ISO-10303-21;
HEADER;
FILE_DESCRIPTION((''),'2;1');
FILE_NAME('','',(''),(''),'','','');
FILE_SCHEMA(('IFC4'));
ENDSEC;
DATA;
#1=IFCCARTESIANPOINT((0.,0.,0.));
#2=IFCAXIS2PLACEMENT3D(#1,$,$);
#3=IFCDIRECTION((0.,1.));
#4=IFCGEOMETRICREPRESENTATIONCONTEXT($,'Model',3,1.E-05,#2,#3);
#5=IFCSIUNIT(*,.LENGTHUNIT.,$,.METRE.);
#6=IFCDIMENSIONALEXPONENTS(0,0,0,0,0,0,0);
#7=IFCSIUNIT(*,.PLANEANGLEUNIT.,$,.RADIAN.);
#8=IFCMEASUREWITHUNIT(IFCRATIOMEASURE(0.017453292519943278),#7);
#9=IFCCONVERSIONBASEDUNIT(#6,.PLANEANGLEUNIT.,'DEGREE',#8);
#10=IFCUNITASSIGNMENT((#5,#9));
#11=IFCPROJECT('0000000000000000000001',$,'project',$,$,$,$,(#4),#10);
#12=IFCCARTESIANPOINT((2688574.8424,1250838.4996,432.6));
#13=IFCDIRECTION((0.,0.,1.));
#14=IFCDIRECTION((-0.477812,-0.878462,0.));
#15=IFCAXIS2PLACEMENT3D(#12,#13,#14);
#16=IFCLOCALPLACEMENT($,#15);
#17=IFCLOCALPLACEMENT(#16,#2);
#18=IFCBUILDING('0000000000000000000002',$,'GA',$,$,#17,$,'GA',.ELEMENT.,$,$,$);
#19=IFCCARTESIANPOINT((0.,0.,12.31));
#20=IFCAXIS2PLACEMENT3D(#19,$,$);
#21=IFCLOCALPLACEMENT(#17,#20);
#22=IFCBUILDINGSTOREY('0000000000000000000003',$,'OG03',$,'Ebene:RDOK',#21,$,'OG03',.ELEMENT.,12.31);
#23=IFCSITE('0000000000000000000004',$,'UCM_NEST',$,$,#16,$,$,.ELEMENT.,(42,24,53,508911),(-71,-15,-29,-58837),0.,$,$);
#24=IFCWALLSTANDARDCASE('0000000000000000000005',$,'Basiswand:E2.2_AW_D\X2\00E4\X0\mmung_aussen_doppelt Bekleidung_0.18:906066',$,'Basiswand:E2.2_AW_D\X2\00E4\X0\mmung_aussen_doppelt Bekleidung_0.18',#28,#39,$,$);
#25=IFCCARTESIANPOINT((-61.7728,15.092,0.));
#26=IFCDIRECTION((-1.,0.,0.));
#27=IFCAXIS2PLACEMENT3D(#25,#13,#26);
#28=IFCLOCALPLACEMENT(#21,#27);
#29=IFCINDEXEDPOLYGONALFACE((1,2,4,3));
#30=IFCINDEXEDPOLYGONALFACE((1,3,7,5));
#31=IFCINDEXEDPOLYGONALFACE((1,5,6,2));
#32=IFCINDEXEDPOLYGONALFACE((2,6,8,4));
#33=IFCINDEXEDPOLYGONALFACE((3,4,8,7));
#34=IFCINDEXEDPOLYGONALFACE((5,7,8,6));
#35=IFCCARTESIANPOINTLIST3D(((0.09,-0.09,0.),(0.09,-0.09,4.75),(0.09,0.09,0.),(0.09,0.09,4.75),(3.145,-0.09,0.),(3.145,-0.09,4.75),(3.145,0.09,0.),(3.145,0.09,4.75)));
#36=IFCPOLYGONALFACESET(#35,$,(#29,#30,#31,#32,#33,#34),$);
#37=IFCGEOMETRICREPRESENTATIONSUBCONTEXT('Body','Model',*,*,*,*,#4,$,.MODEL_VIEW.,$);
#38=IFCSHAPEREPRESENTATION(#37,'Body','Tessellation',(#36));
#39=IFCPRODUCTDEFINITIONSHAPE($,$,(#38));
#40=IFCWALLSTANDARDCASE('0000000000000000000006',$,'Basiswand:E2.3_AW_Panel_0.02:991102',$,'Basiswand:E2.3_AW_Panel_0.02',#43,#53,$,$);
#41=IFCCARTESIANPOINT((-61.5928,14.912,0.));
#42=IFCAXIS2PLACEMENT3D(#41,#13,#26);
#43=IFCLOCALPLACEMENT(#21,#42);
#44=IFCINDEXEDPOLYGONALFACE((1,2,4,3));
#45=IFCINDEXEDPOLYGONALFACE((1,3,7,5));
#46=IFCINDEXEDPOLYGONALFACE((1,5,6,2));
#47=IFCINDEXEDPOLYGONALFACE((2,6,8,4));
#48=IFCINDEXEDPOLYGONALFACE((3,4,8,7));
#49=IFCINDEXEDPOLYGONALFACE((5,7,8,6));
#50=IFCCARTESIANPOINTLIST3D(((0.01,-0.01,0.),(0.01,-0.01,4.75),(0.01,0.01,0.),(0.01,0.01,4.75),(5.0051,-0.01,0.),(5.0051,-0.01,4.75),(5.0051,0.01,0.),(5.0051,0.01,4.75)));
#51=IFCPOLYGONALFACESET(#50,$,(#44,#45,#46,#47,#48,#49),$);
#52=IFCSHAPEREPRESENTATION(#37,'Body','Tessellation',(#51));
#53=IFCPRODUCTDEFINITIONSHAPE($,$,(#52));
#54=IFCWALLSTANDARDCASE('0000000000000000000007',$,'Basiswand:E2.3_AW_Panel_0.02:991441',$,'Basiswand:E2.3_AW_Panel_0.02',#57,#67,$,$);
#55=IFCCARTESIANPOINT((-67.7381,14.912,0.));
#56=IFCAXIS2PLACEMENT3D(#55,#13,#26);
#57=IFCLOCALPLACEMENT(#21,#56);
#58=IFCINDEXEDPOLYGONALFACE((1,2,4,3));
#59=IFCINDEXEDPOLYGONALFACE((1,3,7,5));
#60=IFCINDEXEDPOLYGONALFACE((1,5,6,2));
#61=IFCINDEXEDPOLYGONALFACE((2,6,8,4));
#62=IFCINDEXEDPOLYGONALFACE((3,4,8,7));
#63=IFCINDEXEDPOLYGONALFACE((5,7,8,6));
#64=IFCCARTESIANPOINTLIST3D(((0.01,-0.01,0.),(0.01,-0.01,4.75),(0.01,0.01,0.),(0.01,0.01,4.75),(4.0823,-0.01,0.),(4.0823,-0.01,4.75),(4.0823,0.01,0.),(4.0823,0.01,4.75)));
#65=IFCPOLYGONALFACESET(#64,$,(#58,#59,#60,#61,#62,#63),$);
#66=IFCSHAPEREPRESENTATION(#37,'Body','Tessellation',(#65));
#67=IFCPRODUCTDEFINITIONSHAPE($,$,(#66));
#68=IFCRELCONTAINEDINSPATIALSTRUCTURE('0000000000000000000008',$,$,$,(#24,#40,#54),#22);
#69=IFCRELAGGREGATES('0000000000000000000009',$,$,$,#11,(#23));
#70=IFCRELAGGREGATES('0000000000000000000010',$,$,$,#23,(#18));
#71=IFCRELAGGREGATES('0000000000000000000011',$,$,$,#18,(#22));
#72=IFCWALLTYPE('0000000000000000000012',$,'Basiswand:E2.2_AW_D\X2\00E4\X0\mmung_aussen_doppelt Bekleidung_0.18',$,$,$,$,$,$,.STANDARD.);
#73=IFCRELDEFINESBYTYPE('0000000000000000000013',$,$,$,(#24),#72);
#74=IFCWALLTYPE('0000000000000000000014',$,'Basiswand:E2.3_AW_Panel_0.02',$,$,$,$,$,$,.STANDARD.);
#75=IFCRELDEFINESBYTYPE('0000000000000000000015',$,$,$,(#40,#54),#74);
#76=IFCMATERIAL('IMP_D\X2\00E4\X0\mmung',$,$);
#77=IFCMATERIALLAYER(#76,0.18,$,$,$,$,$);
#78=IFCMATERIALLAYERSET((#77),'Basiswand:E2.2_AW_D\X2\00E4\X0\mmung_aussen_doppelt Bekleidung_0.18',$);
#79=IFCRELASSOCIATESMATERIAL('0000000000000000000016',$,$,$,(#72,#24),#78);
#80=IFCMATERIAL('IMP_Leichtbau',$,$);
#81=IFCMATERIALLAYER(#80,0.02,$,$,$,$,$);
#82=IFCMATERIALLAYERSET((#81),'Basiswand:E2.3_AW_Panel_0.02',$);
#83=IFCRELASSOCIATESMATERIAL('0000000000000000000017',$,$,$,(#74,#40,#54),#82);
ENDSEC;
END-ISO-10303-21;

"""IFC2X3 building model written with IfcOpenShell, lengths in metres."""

from ifc_helpers import new_model, entity, si_unit, converted_unit, direction, frame, frame_2d, origin, place, context, subcontext, project, spatial, rectangle, extrude, material, layer, layer_set, layer_usage, type_object, element, save


model = new_model("IFC2X3")

# Units and contexts
model_context = context("Model", 3, precision=1e-05, world=origin(), true_north=direction((0.0, 1.0)))
body_context = subcontext(model_context, "Body", "Model", "MODEL_VIEW")
ifc_project = project(units=[si_unit("LENGTHUNIT", "METRE"), converted_unit("PLANEANGLEUNIT", "DEGREE", entity("IfcRatioMeasure", 0.017453292519943278), si_unit("PLANEANGLEUNIT", "RADIAN"), dimensions=[0, 0, 0, 0, 0, 0, 0])], contexts=[model_context])

# Site, building, storey
site_placement = place(None, frame((2688574.8424, 1250838.4996, 432.6), z_axis=(0.0, 0.0, 1.0), x_axis=(-0.477812, -0.878462, 0.0)))
site = spatial("IfcSite", under=ifc_project, at=site_placement, Name="UCM_NEST", CompositionType="ELEMENT", RefLatitude=(42, 24, 53, 508911), RefLongitude=(-71, -15, -29, -58837), RefElevation=0.0)
building_placement = place(site_placement, origin())
building = spatial("IfcBuilding", under=site, at=building_placement, Name="GA", LongName="GA", CompositionType="ELEMENT")
storey_placement = place(building_placement, frame((0.0, 0.0, 12.31)))
storey = spatial("IfcBuildingStorey", under=building, at=storey_placement, Name="OG03", ObjectType="Ebene:RDOK", LongName="OG03", CompositionType="ELEMENT", Elevation=12.31)

# Wall
ifc_material_1 = material(Name="IMP_Dämmung")
ifc_layer_1 = layer(ifc_material_1, 0.18)
ifc_layer_set_1 = layer_set([ifc_layer_1], Name="Basiswand:E2.2_AW_Dämmung_aussen_doppelt Bekleidung_0.18")
ifc_layer_usage_1 = layer_usage(ifc_layer_set_1, "AXIS2", "NEGATIVE", 0.09)
wall_type_1 = type_object("IfcWallType", Name="Basiswand:E2.2_AW_Dämmung_aussen_doppelt Bekleidung_0.18", PredefinedType="STANDARD", material=ifc_layer_set_1)
wall_1_placement = place(storey_placement, frame((-61.7728, 15.092, 0.0), z_axis=(0.0, 0.0, 1.0), x_axis=(-1.0, 0.0, 0.0)))
element("IfcWallStandardCase", 1, at=wall_1_placement, inside=storey, type_object=wall_type_1, material=ifc_layer_usage_1, Name="Basiswand:E2.2_AW_Dämmung_aussen_doppelt Bekleidung_0.18:906066", ObjectType="Basiswand:E2.2_AW_Dämmung_aussen_doppelt Bekleidung_0.18", context=body_context, shape_type="SweptSolid", body=[
    extrude(rectangle(XDim=3.055, YDim=0.18, at=frame_2d((1.6175, 0.0), x_axis=(-1.0, 0.0))), origin(), (0.0, 0.0, 1.0), 4.75),
])

# Walls
ifc_material_2 = material(Name="IMP_Leichtbau")
ifc_layer_2 = layer(ifc_material_2, 0.02)
ifc_layer_set_2 = layer_set([ifc_layer_2], Name="Basiswand:E2.3_AW_Panel_0.02")
ifc_layer_usage_2 = layer_usage(ifc_layer_set_2, "AXIS2", "NEGATIVE", 0.01)
wall_type_2 = type_object("IfcWallType", Name="Basiswand:E2.3_AW_Panel_0.02", PredefinedType="STANDARD", material=ifc_layer_set_2)
wall_2_placement = place(storey_placement, frame((-61.5928, 14.912, 0.0), z_axis=(0.0, 0.0, 1.0), x_axis=(-1.0, 0.0, 0.0)))
element("IfcWallStandardCase", 2, at=wall_2_placement, inside=storey, type_object=wall_type_2, material=ifc_layer_usage_2, Name="Basiswand:E2.3_AW_Panel_0.02:991102", ObjectType="Basiswand:E2.3_AW_Panel_0.02", context=body_context, shape_type="SweptSolid", body=[
    extrude(rectangle(XDim=4.9951, YDim=0.02, at=frame_2d((2.5076, 0.0), x_axis=(-1.0, 0.0))), origin(), (0.0, 0.0, 1.0), 4.75),
])
wall_3_placement = place(storey_placement, frame((-67.7381, 14.912, 0.0), z_axis=(0.0, 0.0, 1.0), x_axis=(-1.0, 0.0, 0.0)))
element("IfcWallStandardCase", 3, at=wall_3_placement, inside=storey, type_object=wall_type_2, material=ifc_layer_usage_2, Name="Basiswand:E2.3_AW_Panel_0.02:991441", ObjectType="Basiswand:E2.3_AW_Panel_0.02", context=body_context, shape_type="SweptSolid", body=[
    extrude(rectangle(XDim=4.0723, YDim=0.02, at=frame_2d((2.0462, 0.0), x_axis=(-1.0, 0.0))), origin(), (0.0, 0.0, 1.0), 4.75),
])

save(model, "model.ifc")
